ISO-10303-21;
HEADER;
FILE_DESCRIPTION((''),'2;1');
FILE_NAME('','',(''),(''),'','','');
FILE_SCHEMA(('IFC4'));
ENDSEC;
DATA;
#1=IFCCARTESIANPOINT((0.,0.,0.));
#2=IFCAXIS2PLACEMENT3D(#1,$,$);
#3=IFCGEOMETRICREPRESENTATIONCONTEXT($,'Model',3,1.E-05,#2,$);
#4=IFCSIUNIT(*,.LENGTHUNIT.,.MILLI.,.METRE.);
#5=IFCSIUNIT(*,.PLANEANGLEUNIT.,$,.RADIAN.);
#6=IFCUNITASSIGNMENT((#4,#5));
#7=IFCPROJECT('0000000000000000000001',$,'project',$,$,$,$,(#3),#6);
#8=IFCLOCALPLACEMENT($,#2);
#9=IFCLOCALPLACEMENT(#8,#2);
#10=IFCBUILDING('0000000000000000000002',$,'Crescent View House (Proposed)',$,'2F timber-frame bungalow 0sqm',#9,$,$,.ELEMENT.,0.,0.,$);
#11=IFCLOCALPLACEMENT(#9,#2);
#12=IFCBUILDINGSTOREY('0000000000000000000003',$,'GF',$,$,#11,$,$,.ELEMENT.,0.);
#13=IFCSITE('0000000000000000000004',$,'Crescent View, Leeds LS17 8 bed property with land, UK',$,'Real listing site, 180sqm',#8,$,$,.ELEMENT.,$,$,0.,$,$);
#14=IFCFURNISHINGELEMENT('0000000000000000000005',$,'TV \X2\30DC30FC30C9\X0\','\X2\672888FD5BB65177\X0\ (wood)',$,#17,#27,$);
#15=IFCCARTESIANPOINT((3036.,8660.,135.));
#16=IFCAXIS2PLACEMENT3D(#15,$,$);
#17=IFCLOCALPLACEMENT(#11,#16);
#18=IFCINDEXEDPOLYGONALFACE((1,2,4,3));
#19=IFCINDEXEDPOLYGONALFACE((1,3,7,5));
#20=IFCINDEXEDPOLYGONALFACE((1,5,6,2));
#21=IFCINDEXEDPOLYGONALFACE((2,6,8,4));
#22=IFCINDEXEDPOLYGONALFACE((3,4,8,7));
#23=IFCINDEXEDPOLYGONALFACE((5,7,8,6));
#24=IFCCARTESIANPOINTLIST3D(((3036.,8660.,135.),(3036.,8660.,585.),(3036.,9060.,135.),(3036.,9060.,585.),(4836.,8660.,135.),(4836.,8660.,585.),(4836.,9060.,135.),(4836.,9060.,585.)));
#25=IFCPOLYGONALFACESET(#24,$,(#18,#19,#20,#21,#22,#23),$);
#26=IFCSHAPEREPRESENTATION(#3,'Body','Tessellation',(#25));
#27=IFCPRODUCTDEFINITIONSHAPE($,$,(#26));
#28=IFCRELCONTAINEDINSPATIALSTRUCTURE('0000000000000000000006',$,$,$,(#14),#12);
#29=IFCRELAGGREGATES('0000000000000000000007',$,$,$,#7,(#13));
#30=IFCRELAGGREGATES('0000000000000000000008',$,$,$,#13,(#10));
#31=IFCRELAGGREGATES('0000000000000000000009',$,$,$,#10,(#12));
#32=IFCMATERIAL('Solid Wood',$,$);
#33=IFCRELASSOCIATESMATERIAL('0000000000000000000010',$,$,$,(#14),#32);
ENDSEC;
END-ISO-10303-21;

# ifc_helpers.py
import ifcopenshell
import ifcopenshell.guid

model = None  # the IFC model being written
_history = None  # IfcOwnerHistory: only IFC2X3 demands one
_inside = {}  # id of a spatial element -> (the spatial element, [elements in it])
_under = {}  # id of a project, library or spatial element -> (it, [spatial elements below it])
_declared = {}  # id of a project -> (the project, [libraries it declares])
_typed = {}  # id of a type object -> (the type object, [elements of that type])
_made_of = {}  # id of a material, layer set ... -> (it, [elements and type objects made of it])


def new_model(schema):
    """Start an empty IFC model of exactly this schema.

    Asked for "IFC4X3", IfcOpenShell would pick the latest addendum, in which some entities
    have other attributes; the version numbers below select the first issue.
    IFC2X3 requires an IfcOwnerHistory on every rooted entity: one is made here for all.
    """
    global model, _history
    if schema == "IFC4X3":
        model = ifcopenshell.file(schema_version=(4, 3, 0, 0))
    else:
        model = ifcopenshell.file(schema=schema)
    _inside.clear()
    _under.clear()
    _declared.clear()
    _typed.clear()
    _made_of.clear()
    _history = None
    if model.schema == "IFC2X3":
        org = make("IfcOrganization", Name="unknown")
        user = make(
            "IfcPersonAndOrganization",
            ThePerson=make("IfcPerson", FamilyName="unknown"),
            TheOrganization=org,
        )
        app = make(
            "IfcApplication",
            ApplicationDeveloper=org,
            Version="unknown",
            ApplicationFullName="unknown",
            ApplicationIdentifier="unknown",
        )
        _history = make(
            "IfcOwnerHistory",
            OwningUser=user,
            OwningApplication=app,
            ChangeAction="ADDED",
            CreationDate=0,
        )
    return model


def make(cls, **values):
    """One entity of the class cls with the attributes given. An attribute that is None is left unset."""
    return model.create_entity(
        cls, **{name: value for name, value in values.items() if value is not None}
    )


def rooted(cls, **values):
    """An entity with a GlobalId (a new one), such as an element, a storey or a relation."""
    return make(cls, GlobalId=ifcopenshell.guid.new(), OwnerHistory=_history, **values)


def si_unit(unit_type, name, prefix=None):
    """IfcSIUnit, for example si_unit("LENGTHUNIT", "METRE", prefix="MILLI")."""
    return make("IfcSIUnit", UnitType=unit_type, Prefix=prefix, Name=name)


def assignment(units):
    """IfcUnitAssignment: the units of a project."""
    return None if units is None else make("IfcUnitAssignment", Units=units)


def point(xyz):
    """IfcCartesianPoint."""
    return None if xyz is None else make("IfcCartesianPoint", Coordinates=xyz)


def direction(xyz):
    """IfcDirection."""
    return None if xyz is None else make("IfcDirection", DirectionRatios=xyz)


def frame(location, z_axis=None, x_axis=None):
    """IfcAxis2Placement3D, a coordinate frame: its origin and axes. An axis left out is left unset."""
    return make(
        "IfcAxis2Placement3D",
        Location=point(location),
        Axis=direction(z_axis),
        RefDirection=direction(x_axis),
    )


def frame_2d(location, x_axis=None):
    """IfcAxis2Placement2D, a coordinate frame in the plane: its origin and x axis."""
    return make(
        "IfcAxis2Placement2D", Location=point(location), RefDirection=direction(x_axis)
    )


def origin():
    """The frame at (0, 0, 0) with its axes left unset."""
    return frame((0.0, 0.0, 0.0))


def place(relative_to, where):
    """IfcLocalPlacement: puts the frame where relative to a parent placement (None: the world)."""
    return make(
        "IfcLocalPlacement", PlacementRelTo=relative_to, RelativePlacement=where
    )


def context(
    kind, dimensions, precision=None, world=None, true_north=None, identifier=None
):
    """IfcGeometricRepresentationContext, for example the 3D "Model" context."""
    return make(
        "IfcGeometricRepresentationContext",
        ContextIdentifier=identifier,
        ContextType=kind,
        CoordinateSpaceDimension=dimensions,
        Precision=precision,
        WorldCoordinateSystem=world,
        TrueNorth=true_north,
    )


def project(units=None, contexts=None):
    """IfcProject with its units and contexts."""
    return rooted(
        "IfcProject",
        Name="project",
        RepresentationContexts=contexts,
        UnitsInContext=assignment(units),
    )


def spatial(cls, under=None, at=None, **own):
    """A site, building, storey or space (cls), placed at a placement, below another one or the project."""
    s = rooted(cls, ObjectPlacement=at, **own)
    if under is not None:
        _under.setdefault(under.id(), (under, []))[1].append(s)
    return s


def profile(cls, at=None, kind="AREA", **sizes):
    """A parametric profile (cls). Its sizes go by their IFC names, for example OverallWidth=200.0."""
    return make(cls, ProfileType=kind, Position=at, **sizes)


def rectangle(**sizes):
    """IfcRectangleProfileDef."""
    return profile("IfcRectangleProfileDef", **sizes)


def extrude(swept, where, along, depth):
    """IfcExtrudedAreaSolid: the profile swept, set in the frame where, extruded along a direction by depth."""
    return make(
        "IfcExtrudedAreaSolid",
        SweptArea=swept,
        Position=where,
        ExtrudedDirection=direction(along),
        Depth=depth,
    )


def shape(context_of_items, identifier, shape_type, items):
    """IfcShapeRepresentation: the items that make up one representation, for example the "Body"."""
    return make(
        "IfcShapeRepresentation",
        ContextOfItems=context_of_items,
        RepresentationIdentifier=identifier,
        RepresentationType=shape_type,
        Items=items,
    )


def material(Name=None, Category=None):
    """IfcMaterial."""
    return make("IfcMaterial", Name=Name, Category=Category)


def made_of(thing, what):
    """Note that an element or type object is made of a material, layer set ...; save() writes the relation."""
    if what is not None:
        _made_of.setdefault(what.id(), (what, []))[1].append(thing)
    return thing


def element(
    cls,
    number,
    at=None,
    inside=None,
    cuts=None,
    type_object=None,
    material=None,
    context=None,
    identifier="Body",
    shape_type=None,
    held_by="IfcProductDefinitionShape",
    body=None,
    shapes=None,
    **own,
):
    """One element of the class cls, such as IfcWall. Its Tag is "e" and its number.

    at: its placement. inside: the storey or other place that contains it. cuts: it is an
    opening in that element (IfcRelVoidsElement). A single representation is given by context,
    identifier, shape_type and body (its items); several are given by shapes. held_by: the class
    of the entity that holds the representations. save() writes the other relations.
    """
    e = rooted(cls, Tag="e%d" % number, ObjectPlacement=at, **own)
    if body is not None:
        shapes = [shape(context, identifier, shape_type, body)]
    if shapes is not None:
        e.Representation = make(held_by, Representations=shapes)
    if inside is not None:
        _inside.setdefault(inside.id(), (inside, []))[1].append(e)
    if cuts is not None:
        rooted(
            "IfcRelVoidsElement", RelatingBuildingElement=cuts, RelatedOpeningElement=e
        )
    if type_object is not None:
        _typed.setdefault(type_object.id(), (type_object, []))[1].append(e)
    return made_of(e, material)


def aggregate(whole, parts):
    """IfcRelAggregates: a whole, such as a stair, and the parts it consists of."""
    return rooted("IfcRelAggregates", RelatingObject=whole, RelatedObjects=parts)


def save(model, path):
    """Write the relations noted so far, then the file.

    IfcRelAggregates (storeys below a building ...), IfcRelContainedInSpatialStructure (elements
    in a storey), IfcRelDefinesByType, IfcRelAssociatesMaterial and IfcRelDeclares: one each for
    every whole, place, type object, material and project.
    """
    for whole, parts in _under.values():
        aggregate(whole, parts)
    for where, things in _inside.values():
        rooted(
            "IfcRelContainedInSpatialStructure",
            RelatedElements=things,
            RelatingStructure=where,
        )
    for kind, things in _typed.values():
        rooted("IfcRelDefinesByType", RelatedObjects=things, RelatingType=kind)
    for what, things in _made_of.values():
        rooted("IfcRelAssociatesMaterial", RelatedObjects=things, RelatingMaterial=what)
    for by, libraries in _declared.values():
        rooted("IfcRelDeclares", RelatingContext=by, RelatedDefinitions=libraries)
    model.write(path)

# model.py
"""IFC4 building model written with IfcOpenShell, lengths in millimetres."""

from ifc_helpers import new_model, si_unit, frame, frame_2d, origin, place, context, project, spatial, rectangle, extrude, material, element, save


model = new_model("IFC4")

# Units and contexts
model_context = context("Model", 3, precision=1e-05, world=origin())
ifc_project = project(units=[si_unit("LENGTHUNIT", "METRE", prefix="MILLI"), si_unit("PLANEANGLEUNIT", "RADIAN")], contexts=[model_context])

# Site, building, storey
site_placement = place(None, origin())
site = spatial("IfcSite", under=ifc_project, at=site_placement, Name="Crescent View, Leeds LS17 8 bed property with land, UK", ObjectType="Real listing site, 180sqm", CompositionType="ELEMENT", RefElevation=0.0)
building_placement = place(site_placement, origin())
building = spatial("IfcBuilding", under=site, at=building_placement, Name="Crescent View House (Proposed)", ObjectType="2F timber-frame bungalow 0sqm", CompositionType="ELEMENT", ElevationOfRefHeight=0.0, ElevationOfTerrain=0.0)
storey_placement = place(building_placement, origin())
storey = spatial("IfcBuildingStorey", under=building, at=storey_placement, Name="GF", CompositionType="ELEMENT", Elevation=0.0)

# Shared definitions
ifc_material_1 = material(Name="Solid Wood")

# Furnishing element
furnishing_placement = place(storey_placement, frame((3036.0, 8660.0, 135.0)))
element("IfcFurnishingElement", 1, at=furnishing_placement, inside=storey, material=ifc_material_1, Name="TV ボード", Description="木製家具 (wood)", context=model_context, shape_type="SweptSolid", body=[
    extrude(rectangle(XDim=1800.0, YDim=400.0, at=frame_2d((900.0, 200.0))), frame((3036.0, 8660.0, 135.0)), (0.0, 0.0, 1.0), 450.0),
])

save(model, "model.ifc")
